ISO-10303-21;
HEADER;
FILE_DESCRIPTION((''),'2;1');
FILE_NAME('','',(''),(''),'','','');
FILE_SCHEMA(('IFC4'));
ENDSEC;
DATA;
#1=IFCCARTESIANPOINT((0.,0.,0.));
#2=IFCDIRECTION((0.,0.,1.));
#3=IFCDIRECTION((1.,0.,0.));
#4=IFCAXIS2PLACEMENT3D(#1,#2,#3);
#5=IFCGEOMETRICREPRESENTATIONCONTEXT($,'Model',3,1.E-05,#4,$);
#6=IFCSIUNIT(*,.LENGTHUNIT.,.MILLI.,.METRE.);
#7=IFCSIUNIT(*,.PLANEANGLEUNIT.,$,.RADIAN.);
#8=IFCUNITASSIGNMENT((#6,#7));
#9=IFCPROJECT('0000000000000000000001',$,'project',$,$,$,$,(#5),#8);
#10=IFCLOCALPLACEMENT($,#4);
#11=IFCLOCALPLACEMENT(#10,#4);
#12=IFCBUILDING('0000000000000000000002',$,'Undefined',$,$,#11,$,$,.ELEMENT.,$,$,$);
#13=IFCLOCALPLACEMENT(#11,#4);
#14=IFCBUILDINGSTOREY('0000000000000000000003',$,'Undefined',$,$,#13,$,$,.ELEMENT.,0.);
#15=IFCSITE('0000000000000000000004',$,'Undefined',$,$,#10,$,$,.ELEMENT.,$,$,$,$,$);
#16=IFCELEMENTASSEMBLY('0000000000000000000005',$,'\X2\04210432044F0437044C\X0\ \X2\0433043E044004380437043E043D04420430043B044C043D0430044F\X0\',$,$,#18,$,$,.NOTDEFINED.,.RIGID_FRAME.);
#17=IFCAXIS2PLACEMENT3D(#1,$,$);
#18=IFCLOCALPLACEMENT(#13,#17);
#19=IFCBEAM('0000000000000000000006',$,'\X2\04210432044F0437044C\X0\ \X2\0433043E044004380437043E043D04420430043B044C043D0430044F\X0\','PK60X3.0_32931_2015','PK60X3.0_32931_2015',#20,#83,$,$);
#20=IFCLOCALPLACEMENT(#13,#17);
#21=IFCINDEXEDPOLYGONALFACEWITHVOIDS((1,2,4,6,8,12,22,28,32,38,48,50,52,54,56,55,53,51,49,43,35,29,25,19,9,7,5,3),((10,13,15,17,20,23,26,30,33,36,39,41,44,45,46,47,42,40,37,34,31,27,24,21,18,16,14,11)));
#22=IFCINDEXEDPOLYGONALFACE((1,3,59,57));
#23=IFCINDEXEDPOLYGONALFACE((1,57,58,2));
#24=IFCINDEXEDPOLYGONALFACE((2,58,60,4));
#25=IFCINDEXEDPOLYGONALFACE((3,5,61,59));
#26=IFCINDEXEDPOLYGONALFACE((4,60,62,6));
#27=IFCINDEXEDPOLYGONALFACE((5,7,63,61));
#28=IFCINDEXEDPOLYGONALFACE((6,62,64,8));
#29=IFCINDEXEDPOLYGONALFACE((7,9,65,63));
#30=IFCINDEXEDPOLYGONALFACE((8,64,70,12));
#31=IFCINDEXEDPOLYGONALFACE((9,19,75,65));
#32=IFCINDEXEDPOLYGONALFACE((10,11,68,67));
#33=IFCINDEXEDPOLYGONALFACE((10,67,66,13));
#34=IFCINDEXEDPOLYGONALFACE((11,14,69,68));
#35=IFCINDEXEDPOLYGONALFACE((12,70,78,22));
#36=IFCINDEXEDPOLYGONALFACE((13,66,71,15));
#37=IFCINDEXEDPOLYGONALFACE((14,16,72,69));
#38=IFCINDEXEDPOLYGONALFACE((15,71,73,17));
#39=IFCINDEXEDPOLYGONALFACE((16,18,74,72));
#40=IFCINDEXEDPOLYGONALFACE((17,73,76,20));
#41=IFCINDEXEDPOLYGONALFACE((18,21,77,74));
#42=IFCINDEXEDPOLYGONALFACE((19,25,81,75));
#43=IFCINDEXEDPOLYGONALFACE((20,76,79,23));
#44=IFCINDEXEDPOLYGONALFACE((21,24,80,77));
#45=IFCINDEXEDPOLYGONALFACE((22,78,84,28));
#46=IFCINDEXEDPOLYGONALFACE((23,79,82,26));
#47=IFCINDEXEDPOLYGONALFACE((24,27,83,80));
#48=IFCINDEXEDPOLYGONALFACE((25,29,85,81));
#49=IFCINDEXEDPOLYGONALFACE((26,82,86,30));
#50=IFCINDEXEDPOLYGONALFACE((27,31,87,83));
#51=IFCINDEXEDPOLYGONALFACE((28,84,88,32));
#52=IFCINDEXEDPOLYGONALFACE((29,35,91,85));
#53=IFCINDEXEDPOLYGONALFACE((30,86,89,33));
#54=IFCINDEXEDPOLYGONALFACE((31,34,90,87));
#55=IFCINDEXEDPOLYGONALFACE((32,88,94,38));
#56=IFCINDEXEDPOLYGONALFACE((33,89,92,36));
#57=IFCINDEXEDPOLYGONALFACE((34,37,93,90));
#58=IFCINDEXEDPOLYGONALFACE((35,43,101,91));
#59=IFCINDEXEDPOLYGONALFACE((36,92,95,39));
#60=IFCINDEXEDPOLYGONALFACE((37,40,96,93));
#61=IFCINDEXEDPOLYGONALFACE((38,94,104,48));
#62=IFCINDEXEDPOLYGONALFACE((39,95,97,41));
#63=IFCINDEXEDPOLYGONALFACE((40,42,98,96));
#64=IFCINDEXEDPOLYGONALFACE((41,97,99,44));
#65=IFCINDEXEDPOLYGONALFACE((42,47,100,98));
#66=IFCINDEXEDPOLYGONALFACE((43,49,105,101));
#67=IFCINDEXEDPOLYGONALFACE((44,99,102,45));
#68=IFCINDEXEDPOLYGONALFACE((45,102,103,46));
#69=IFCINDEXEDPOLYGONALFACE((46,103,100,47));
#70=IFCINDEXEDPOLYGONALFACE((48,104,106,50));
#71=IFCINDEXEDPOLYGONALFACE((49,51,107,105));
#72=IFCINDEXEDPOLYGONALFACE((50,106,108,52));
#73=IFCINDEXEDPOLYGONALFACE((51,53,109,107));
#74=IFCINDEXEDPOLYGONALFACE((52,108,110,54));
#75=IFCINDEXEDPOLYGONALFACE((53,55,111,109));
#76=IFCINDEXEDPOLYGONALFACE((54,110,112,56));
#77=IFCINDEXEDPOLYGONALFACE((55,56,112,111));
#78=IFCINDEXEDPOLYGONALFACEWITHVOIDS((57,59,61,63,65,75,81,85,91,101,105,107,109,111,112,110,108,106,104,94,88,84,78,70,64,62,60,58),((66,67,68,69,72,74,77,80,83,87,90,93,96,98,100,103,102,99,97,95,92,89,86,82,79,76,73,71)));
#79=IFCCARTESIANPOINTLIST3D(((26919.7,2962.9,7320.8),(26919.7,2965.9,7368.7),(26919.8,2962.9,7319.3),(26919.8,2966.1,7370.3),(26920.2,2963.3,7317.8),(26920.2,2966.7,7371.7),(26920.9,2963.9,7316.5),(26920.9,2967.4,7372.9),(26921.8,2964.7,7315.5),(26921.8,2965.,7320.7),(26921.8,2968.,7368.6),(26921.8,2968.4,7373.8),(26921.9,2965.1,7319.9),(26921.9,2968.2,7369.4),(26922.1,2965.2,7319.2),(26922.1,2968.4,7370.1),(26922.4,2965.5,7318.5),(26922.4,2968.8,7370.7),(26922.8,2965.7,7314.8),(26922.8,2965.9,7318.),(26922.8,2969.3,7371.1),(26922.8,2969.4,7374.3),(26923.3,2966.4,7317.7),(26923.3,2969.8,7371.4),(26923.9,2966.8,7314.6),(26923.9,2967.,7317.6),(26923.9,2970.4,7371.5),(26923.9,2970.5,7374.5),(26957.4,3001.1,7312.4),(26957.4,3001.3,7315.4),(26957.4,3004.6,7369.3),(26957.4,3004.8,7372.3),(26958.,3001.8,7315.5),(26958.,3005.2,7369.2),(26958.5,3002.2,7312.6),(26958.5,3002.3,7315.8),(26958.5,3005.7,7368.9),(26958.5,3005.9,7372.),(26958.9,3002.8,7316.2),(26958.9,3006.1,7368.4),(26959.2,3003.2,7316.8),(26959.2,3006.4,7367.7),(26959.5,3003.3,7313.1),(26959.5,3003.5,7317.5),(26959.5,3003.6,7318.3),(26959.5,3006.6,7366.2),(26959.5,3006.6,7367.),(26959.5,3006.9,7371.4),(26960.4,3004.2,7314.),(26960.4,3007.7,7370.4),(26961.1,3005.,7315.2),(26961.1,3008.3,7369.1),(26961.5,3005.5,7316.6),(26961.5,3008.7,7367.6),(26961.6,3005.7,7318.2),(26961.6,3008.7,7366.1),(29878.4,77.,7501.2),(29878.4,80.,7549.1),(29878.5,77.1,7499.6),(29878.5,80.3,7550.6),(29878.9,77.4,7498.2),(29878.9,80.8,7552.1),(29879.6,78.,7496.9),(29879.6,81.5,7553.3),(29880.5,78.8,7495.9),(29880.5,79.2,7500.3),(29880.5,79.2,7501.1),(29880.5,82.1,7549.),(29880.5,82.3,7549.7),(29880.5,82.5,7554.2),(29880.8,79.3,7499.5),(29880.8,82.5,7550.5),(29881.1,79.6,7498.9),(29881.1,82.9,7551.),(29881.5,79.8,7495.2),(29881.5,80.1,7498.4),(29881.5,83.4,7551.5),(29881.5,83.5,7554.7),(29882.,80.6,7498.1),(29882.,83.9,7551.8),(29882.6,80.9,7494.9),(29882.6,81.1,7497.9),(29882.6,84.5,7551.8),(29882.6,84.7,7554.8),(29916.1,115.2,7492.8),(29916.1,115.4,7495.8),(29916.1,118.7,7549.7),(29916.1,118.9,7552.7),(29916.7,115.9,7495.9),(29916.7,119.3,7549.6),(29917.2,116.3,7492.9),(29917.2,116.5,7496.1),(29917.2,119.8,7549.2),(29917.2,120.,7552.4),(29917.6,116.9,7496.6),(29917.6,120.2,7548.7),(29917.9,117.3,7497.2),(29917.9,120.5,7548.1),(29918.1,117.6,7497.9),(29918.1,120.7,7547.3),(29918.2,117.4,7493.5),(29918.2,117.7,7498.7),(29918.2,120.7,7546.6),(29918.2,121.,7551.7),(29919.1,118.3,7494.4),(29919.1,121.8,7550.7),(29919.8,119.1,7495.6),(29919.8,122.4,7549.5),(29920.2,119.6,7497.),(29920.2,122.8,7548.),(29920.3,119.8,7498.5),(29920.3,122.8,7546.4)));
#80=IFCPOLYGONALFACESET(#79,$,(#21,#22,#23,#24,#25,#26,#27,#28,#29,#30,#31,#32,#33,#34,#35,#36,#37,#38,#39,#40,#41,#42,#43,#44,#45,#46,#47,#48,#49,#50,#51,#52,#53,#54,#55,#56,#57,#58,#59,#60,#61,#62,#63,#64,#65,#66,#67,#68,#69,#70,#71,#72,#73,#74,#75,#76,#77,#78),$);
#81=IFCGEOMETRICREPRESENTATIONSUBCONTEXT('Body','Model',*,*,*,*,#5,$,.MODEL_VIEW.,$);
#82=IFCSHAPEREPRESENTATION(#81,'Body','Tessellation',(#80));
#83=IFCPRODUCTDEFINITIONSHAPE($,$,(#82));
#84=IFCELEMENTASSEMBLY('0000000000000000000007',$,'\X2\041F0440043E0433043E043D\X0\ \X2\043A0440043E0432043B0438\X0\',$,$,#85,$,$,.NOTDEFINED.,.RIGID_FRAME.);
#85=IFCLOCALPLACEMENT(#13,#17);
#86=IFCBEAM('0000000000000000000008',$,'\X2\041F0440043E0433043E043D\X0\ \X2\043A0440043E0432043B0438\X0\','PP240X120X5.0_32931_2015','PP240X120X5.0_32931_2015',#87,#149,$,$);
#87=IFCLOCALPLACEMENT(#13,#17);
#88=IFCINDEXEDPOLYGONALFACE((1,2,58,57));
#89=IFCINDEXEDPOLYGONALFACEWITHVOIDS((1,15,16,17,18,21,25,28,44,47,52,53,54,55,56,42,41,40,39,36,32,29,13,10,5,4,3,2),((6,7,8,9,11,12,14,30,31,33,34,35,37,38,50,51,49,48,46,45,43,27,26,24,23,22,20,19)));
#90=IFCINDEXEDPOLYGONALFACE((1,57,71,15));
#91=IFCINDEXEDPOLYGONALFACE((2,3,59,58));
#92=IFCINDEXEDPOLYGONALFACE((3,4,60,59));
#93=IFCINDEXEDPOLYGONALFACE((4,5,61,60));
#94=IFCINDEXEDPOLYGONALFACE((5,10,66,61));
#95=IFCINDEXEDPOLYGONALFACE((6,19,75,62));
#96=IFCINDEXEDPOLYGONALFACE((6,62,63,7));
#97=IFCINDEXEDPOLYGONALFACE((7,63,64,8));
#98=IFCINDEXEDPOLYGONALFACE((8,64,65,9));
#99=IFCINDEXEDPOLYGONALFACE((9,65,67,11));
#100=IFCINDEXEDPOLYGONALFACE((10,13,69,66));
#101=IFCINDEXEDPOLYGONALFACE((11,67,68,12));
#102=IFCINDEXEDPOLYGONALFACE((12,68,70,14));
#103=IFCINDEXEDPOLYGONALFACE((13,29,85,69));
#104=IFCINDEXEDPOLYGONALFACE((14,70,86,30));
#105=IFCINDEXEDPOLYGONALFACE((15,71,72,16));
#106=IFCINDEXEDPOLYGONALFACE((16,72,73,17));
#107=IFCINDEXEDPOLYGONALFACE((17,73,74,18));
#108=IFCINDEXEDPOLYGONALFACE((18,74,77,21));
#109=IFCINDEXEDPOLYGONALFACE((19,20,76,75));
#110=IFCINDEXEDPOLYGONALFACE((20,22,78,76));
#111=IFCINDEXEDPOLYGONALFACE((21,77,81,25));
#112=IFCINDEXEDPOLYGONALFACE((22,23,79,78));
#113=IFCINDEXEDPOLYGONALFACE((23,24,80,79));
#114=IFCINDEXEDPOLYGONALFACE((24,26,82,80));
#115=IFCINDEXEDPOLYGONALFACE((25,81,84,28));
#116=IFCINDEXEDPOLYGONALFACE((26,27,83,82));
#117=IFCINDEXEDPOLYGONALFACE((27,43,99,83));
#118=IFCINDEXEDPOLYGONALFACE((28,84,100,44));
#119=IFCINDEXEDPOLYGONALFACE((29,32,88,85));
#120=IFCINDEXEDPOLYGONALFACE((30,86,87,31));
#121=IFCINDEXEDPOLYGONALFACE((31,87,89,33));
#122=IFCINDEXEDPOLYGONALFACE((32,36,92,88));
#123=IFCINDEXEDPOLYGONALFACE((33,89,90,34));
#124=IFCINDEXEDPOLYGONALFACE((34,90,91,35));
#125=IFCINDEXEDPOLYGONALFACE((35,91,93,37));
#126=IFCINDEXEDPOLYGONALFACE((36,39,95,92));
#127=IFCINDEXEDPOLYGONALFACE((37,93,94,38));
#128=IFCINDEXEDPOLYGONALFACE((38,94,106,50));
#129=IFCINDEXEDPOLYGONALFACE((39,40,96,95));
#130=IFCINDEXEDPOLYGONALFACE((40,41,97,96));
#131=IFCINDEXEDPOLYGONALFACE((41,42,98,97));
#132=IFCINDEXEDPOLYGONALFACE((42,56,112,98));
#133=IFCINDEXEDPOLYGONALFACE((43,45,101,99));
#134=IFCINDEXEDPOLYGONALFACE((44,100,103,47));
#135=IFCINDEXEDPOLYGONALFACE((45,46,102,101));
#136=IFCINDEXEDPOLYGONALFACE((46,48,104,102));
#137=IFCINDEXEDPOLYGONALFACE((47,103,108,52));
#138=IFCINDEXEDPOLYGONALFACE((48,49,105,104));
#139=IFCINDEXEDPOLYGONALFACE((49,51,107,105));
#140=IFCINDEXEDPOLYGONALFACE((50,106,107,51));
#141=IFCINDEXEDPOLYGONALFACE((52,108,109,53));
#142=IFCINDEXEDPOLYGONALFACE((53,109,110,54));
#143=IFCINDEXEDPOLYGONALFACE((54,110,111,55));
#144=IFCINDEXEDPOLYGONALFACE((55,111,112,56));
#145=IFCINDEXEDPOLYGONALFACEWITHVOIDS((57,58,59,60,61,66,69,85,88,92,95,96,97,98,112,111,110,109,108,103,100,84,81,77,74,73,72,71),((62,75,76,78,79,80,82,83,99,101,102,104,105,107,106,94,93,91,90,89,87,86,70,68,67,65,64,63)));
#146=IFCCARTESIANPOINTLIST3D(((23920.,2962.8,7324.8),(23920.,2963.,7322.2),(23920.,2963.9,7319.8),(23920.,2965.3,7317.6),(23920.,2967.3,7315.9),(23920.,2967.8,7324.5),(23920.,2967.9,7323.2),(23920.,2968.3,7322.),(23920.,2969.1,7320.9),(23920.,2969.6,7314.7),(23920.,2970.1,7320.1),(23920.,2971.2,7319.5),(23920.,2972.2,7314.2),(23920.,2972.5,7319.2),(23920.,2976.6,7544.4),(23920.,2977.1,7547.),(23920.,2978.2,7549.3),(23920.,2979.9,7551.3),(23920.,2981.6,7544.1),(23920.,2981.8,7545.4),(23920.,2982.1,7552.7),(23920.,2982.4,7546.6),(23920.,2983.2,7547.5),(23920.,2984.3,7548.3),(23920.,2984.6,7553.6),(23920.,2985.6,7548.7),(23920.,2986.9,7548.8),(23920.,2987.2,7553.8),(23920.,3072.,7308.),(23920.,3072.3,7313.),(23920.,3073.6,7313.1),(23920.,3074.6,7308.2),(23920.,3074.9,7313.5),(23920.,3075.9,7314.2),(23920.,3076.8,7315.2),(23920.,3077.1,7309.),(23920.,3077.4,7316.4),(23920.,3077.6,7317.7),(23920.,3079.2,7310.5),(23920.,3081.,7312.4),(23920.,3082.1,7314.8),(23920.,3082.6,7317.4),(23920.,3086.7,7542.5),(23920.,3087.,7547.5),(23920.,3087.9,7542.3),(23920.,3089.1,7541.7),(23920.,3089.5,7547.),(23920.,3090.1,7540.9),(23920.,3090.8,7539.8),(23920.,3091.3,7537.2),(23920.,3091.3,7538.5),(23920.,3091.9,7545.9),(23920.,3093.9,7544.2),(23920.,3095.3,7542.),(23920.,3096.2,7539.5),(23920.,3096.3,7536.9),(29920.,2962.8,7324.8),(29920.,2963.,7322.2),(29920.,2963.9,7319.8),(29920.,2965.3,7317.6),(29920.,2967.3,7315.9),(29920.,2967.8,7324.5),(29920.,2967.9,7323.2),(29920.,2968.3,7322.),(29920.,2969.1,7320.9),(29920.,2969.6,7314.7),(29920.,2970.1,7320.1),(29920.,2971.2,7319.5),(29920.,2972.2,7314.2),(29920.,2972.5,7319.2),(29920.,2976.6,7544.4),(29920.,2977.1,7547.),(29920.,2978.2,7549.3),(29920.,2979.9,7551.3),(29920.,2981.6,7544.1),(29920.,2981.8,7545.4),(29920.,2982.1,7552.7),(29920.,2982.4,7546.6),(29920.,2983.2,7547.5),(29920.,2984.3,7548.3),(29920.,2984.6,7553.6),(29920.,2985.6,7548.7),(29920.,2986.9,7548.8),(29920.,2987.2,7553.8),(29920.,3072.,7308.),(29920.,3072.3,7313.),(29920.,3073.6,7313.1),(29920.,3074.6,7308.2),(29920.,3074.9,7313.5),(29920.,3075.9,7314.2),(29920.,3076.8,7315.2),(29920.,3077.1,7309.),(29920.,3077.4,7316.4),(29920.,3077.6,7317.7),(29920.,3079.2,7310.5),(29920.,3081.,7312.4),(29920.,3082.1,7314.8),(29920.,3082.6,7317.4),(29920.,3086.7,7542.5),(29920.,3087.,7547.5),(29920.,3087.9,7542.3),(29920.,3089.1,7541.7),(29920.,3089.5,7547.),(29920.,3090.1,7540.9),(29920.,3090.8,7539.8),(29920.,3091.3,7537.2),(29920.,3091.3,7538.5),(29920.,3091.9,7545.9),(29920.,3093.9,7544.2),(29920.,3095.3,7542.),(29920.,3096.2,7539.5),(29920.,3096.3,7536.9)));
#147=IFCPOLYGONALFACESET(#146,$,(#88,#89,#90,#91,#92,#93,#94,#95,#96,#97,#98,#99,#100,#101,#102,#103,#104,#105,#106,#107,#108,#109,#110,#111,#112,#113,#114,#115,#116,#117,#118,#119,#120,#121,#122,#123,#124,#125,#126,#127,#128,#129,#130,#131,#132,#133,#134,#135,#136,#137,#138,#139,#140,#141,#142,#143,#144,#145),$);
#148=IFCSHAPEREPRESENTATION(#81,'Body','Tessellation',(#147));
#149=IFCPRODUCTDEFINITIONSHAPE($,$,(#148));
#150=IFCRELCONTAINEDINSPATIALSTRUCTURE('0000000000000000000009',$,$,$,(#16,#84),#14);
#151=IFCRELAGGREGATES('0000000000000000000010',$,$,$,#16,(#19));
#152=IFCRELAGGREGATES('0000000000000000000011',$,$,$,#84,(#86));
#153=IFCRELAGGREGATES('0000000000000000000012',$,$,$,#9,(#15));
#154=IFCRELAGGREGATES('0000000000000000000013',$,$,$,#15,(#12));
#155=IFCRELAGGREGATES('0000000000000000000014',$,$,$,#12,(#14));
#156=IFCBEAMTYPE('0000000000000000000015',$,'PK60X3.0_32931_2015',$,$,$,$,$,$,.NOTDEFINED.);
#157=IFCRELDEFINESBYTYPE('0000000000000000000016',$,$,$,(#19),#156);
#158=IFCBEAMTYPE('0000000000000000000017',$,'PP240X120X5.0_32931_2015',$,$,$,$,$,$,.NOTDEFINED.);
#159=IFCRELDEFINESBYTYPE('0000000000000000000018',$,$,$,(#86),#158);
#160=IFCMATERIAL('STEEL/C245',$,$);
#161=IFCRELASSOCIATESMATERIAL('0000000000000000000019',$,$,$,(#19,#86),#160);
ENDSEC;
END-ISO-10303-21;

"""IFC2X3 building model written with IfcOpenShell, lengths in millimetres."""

from ifc_helpers import new_model, si_unit, frame, origin_with_axes, origin_2d_with_axis, place, context, subcontext, project, spatial, hollow_rectangle, extrude, material, type_object, element, aggregate, save


model = new_model("IFC2X3")

# Units and contexts
model_context = context("Model", 3, precision=1e-05, world=origin_with_axes())
body_context = subcontext(model_context, "Body", "Model", "MODEL_VIEW")
ifc_project = project(units=[si_unit("LENGTHUNIT", "METRE", prefix="MILLI"), si_unit("PLANEANGLEUNIT", "RADIAN")], contexts=[model_context])

# Site, building, storey
site_placement = place(None, origin_with_axes())
site = spatial("IfcSite", under=ifc_project, at=site_placement, Name="Undefined", CompositionType="ELEMENT")
building_placement = place(site_placement, origin_with_axes())
building = spatial("IfcBuilding", under=site, at=building_placement, Name="Undefined", CompositionType="ELEMENT")
storey_placement = place(building_placement, origin_with_axes())
storey = spatial("IfcBuildingStorey", under=building, at=storey_placement, Name="Undefined", CompositionType="ELEMENT", Elevation=0.0)

# Shared definitions
ifc_material = material(Name="STEEL/C245")

# Element assemblies, beams
beam_type_1 = type_object("IfcBeamType", Name="PK60X3.0_32931_2015", PredefinedType="NOTDEFINED")
assembly_1_placement = place(storey_placement, origin_with_axes())
assembly_1 = element("IfcElementAssembly", 1, at=assembly_1_placement, inside=storey, Name="Связь горизонтальная", AssemblyPlace="NOTDEFINED", PredefinedType="RIGID_FRAME")
beam_1_placement = place(assembly_1_placement, frame((29899.3, 99.9, 7523.8), z_axis=(0.0, 0.062378, 0.998053), x_axis=(-0.715179, 0.69758, -0.043599)))
beam_1 = element("IfcBeam", 2, at=beam_1_placement, type_object=beam_type_1, material=ifc_material, Name="Связь горизонтальная", Description="PK60X3.0_32931_2015", ObjectType="PK60X3.0_32931_2015", context=body_context, shape_type="SweptSolid", body=[
    extrude(hollow_rectangle(XDim=60.0, YDim=60.0, WallThickness=3.0, InnerFilletRadius=3.0, OuterFilletRadius=6.0, at=origin_2d_with_axis()), frame((4137.0, 0.0, 0.0), z_axis=(-1.0, 0.0, 0.0), x_axis=(0.0, -1.0, 0.0)), (0.0, 0.0, 1.0), 4137.0),
])
aggregate(assembly_1, [beam_1])
assembly_2_placement = place(storey_placement, origin_with_axes())
assembly_2 = element("IfcElementAssembly", 3, at=assembly_2_placement, inside=storey, Name="Прогон кровли", AssemblyPlace="NOTDEFINED", PredefinedType="RIGID_FRAME")
beam_type_2 = type_object("IfcBeamType", Name="PP240X120X5.0_32931_2015", PredefinedType="NOTDEFINED")
beam_2_placement = place(assembly_2_placement, frame((29920.0, 3029.6, 7430.9), z_axis=(0.0, 0.062378, 0.998053), x_axis=(-1.0, 0.0, 0.0)))
beam_2 = element("IfcBeam", 4, at=beam_2_placement, type_object=beam_type_2, material=ifc_material, Name="Прогон кровли", Description="PP240X120X5.0_32931_2015", ObjectType="PP240X120X5.0_32931_2015", context=body_context, shape_type="SweptSolid", body=[
    extrude(hollow_rectangle(XDim=120.0, YDim=240.0, WallThickness=5.0, InnerFilletRadius=5.0, OuterFilletRadius=10.0, at=origin_2d_with_axis()), frame((6000.0, 0.0, 0.0), z_axis=(-1.0, 0.0, 0.0), x_axis=(0.0, -1.0, 0.0)), (0.0, 0.0, 1.0), 6000.0),
])
aggregate(assembly_2, [beam_2])

save(model, "model.ifc")
